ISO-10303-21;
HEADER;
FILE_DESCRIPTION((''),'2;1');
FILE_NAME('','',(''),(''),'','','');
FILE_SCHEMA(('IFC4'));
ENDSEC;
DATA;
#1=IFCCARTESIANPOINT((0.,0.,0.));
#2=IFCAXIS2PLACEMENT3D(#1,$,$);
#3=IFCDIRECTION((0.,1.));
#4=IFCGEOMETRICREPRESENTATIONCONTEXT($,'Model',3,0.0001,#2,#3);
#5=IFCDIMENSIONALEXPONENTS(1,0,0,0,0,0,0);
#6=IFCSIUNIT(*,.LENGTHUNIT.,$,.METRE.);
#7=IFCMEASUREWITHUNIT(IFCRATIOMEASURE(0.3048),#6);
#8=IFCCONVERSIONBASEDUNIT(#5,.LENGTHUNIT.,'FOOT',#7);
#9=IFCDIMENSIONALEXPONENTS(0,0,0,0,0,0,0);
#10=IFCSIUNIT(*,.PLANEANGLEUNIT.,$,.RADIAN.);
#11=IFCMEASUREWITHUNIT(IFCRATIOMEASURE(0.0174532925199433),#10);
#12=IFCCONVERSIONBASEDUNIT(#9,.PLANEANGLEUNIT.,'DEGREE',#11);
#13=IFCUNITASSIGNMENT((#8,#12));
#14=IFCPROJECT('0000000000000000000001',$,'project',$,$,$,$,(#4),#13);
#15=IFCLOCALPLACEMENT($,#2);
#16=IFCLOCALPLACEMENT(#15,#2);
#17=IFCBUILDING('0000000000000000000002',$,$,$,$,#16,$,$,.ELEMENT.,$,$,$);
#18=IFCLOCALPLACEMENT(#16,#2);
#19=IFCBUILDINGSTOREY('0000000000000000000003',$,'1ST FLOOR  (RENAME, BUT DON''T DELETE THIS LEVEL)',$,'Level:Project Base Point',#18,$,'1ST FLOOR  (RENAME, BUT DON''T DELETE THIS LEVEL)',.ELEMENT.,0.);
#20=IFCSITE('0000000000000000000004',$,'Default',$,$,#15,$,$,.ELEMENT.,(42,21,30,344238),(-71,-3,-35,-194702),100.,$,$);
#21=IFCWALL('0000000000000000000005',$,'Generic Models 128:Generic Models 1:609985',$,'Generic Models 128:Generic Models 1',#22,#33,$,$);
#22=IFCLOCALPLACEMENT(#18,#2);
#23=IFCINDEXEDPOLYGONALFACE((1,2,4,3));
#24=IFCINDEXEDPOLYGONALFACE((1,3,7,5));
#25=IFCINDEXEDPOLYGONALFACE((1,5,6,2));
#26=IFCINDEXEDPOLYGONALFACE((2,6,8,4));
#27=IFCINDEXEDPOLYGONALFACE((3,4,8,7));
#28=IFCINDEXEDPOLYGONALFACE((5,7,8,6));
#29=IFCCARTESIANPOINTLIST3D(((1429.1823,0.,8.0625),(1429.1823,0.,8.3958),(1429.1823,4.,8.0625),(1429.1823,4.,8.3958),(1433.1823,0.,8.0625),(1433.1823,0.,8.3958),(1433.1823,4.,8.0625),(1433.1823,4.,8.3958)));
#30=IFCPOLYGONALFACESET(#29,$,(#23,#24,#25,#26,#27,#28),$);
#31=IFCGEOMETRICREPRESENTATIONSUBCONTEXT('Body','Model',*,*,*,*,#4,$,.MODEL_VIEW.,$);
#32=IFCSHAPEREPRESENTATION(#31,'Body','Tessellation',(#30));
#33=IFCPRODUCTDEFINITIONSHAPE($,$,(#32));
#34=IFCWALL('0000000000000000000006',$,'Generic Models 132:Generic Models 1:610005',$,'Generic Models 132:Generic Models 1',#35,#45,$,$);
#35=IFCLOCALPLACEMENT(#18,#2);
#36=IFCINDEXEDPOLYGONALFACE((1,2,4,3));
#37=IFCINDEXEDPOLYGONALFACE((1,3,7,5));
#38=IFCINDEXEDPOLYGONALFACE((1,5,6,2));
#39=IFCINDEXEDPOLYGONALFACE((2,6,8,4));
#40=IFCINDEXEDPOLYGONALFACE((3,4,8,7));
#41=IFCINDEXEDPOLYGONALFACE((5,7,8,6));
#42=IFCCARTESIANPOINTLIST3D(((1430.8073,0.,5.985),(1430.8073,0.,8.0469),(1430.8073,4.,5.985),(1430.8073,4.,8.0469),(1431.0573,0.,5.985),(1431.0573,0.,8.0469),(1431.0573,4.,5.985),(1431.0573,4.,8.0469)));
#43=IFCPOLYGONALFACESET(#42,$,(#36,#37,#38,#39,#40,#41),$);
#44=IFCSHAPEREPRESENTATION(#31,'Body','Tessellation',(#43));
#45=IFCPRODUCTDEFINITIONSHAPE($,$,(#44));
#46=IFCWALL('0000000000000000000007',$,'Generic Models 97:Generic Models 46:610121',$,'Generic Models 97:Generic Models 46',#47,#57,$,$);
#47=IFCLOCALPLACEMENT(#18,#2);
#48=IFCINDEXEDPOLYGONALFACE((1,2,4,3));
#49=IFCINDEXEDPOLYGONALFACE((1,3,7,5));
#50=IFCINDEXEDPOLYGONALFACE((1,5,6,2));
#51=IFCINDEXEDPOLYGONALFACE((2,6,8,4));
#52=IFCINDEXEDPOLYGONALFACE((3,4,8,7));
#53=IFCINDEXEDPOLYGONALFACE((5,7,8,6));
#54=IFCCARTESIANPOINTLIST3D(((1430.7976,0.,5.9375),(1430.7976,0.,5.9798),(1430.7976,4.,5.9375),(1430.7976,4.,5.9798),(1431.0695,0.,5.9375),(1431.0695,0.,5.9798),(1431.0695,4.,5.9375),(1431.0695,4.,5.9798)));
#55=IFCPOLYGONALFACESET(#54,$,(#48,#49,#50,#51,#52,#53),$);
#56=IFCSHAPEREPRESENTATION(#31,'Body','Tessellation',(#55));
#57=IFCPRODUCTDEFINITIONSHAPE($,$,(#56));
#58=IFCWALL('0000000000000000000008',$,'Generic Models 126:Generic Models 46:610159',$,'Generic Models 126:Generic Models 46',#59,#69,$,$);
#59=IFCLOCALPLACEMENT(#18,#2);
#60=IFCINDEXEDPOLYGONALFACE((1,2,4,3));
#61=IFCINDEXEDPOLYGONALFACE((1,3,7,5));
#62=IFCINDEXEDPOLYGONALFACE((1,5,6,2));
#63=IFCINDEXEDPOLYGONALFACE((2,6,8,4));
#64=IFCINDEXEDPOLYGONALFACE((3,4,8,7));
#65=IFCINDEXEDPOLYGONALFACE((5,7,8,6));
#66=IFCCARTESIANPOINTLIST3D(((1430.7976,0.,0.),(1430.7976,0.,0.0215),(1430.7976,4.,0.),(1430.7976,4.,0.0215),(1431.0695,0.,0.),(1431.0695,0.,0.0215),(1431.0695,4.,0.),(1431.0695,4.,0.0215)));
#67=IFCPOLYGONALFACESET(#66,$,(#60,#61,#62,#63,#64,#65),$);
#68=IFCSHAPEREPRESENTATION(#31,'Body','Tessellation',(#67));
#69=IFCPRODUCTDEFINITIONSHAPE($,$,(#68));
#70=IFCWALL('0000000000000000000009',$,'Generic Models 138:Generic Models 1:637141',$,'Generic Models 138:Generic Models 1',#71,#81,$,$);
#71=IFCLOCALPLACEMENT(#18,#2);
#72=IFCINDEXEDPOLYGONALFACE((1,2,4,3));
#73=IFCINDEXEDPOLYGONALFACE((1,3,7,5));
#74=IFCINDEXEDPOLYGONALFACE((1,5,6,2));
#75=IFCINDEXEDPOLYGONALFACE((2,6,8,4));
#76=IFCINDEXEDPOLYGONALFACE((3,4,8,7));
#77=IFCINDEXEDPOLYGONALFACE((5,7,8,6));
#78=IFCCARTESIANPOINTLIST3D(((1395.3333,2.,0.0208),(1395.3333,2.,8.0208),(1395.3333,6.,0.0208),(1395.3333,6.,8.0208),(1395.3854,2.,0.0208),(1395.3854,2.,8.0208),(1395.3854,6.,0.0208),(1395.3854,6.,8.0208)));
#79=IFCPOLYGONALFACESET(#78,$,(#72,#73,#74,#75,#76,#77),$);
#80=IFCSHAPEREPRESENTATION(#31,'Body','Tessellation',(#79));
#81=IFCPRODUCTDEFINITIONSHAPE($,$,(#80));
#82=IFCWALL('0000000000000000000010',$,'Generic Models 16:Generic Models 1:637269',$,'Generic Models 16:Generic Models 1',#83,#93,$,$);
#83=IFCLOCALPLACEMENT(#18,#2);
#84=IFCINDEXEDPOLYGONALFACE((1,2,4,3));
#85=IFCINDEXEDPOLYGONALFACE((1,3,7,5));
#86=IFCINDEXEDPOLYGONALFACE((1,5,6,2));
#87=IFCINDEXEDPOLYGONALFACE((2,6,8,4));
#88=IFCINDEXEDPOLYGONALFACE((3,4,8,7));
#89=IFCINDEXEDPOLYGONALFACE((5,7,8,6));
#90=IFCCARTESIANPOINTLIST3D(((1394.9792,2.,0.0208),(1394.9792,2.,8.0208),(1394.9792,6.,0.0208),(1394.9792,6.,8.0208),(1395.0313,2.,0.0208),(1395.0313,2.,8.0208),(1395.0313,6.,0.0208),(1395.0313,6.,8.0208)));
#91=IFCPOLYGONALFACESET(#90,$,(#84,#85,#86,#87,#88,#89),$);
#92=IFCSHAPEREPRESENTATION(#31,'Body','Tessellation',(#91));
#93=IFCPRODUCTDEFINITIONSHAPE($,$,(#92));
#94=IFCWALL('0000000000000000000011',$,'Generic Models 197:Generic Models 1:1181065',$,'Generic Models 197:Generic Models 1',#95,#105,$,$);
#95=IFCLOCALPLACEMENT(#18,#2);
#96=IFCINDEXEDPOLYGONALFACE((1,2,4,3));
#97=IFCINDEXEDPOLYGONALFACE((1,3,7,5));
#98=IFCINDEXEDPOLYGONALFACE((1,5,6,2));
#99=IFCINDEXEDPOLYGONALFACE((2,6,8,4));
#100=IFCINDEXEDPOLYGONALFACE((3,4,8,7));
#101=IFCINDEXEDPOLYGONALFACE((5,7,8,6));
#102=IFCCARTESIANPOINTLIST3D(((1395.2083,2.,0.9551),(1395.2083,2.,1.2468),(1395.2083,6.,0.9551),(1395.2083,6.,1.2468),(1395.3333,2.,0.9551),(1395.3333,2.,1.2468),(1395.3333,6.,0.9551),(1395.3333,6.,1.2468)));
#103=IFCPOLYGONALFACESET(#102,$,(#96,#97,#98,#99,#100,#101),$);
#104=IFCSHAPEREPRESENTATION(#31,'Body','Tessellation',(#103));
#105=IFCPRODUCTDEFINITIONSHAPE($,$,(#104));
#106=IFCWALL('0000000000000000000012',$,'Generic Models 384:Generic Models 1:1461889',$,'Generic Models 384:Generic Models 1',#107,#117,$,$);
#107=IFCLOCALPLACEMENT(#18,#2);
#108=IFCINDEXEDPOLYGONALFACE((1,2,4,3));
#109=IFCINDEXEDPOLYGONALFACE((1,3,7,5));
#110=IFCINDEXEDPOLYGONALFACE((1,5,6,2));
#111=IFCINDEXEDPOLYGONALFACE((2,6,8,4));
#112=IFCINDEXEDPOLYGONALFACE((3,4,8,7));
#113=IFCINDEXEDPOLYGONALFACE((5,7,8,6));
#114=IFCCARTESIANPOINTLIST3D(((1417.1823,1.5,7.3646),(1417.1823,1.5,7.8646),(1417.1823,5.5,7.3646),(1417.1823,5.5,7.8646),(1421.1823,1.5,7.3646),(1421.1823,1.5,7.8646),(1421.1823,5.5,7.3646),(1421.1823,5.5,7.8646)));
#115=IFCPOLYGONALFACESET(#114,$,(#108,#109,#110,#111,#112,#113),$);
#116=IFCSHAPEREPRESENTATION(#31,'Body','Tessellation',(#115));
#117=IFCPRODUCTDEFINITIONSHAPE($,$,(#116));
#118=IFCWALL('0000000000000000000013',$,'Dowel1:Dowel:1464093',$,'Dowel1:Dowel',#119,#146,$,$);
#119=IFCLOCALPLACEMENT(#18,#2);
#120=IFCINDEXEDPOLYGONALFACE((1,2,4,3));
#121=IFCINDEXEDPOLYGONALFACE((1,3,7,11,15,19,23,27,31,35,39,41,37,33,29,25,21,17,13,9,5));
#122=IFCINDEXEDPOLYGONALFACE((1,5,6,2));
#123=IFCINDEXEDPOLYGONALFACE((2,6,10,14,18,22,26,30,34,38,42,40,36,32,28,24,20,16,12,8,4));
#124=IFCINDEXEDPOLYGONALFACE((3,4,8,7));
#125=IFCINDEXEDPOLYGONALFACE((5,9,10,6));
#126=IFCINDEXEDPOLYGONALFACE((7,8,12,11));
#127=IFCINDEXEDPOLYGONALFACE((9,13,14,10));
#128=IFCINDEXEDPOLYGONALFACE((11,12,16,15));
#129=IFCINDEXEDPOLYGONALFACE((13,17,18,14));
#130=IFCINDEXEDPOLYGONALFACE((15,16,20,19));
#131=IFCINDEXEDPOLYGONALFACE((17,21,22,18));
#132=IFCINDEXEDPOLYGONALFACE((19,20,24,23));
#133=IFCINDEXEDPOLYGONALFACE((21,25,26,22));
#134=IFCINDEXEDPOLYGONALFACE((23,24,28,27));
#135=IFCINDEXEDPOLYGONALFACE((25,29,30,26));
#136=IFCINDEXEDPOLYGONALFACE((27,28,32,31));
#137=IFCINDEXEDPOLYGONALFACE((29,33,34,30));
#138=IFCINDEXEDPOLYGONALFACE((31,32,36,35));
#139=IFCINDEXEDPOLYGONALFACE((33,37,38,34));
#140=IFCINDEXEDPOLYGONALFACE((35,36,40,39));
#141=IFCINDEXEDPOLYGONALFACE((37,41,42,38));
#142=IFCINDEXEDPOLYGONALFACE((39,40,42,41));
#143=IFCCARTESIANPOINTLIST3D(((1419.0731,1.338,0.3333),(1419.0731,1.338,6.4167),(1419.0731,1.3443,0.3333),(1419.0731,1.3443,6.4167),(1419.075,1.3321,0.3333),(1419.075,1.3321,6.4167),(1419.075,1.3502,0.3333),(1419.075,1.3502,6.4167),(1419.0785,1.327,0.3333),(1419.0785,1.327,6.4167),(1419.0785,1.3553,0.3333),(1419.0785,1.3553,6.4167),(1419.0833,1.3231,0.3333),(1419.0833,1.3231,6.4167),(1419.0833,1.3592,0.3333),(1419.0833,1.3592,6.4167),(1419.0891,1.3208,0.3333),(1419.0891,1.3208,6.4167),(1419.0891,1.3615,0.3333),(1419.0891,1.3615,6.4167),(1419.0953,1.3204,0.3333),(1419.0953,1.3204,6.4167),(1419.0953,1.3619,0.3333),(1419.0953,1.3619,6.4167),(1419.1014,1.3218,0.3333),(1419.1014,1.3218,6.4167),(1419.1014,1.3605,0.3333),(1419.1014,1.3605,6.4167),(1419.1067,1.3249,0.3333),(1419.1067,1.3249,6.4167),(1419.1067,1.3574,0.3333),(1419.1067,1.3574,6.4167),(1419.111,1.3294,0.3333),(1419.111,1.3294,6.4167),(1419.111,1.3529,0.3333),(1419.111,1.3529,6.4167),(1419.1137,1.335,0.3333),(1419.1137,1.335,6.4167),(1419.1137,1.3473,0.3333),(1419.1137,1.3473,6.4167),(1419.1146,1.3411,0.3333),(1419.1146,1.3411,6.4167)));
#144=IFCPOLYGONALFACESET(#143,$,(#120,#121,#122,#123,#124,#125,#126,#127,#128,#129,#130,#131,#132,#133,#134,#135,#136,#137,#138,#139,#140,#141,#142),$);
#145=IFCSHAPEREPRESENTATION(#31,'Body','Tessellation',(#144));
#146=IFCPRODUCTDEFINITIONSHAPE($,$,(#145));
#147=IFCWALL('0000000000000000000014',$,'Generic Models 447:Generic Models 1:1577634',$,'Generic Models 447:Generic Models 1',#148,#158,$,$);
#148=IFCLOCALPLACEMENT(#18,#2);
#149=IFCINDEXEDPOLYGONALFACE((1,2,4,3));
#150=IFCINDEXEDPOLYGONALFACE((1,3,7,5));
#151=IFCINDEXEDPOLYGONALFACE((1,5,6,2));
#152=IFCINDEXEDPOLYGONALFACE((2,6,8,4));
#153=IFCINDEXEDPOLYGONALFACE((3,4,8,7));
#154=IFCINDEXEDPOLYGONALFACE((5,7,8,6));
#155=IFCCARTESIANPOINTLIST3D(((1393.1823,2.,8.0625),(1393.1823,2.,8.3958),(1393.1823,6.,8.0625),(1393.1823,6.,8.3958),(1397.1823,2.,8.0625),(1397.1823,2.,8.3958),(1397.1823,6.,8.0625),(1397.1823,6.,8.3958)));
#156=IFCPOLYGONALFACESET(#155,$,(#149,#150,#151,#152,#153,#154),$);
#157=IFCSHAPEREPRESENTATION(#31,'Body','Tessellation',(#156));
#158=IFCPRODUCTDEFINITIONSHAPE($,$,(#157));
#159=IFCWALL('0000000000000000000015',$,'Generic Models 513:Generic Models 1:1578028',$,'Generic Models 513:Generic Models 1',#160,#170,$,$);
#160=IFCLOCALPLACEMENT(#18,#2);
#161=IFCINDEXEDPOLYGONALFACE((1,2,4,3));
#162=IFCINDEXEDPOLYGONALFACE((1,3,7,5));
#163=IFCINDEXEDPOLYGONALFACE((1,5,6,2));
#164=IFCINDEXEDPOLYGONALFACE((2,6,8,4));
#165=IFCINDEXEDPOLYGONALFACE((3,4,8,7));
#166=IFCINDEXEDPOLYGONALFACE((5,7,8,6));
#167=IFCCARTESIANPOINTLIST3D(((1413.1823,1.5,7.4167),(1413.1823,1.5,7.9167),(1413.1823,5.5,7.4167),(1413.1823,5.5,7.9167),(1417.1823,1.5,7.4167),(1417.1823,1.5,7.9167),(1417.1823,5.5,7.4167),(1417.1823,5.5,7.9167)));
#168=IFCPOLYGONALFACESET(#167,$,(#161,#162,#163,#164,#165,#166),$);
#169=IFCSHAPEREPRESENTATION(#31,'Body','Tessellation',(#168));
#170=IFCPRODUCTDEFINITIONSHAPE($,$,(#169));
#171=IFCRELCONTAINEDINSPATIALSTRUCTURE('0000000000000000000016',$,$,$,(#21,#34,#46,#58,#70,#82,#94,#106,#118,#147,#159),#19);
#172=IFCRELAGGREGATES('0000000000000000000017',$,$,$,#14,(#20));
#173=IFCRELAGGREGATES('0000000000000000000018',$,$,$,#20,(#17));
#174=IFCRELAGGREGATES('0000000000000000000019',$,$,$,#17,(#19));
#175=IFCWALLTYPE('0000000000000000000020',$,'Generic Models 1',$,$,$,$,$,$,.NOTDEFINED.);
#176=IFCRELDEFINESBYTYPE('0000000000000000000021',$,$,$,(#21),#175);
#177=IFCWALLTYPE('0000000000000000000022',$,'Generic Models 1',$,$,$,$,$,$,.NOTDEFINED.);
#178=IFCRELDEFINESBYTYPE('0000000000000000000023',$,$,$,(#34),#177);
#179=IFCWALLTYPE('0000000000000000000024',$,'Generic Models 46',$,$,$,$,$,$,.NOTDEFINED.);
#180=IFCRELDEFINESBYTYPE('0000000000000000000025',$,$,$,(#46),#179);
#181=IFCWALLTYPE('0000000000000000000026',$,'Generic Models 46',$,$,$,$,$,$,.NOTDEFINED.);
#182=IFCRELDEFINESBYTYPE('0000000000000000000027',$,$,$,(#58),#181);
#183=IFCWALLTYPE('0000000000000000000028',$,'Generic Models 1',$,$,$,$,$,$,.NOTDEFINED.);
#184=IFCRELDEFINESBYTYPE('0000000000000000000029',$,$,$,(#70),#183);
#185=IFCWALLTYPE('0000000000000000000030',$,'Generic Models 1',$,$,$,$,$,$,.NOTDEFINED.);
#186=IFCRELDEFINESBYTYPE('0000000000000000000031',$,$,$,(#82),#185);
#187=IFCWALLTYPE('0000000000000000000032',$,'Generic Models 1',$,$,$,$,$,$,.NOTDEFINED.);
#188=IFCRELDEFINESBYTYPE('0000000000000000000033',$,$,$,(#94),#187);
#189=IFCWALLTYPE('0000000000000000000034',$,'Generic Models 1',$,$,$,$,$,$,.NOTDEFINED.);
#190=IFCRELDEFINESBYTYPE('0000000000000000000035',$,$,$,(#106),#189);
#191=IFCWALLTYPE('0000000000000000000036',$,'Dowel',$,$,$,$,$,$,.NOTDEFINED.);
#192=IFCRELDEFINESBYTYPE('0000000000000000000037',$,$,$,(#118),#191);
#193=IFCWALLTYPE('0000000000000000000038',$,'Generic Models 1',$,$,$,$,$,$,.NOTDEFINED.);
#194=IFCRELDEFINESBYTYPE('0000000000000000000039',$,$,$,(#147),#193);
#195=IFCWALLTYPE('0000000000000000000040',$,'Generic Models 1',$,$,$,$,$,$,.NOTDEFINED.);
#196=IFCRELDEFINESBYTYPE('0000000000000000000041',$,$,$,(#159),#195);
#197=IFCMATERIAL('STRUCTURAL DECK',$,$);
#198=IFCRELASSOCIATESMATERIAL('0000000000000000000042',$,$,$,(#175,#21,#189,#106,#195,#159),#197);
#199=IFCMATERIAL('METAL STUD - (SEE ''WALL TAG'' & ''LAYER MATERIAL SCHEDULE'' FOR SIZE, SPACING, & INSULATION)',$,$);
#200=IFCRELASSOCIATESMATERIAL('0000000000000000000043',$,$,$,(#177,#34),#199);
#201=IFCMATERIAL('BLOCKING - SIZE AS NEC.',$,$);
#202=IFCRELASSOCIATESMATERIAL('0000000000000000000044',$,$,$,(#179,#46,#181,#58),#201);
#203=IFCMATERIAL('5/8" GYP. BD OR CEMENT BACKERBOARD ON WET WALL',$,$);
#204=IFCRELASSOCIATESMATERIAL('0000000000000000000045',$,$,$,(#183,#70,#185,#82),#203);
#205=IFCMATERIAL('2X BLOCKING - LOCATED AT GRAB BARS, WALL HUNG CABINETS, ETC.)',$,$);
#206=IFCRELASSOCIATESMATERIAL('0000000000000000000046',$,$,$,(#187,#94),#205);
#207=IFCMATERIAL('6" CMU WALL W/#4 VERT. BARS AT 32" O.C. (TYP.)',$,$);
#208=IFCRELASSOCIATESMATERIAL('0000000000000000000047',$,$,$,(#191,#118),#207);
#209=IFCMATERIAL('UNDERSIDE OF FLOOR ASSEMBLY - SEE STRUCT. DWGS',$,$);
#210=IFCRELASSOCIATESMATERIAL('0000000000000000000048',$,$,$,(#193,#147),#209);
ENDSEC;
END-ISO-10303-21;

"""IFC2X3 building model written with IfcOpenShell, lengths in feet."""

from ifc_helpers import new_model, entity, si_unit, converted_unit, direction, frame, frame_2d, origin, origin_2d_with_axis, place, context, subcontext, project, spatial, rectangle, circle, extrude, material, type_object, element, save


model = new_model("IFC2X3")

# Units and contexts
model_context = context("Model", 3, precision=0.0001, world=origin(), true_north=direction((0.0, 1.0)))
body_context = subcontext(model_context, "Body", "Model", "MODEL_VIEW")
ifc_project = project(units=[converted_unit("LENGTHUNIT", "FOOT", entity("IfcRatioMeasure", 0.3048), si_unit("LENGTHUNIT", "METRE"), dimensions=[1, 0, 0, 0, 0, 0, 0]), converted_unit("PLANEANGLEUNIT", "DEGREE", entity("IfcRatioMeasure", 0.0174532925199433), si_unit("PLANEANGLEUNIT", "RADIAN"), dimensions=[0, 0, 0, 0, 0, 0, 0])], contexts=[model_context])

# Site, building, storey
site_placement = place(None, origin())
site = spatial("IfcSite", under=ifc_project, at=site_placement, Name="Default", CompositionType="ELEMENT", RefLatitude=(42, 21, 30, 344238), RefLongitude=(-71, -3, -35, -194702), RefElevation=100.0)
building_placement = place(site_placement, origin())
building = spatial("IfcBuilding", under=site, at=building_placement, CompositionType="ELEMENT")
storey_placement = place(building_placement, origin())
storey = spatial("IfcBuildingStorey", under=building, at=storey_placement, Name="1ST FLOOR  (RENAME, BUT DON'T DELETE THIS LEVEL)", ObjectType="Level:Project Base Point", LongName="1ST FLOOR  (RENAME, BUT DON'T DELETE THIS LEVEL)", CompositionType="ELEMENT", Elevation=0.0)

# Walls
ifc_material_1 = material(Name="STRUCTURAL DECK")
wall_type_1 = type_object("IfcWallType", Name="Generic Models 1", PredefinedType="NOTDEFINED", material=ifc_material_1)
wall_1_placement = place(storey_placement, frame((1429.1823, 0.0, 8.0625), z_axis=(0.0, 0.0, 1.0), x_axis=(0.0, 1.0, 0.0)))
element("IfcWall", 1, at=wall_1_placement, inside=storey, type_object=wall_type_1, material=ifc_material_1, Name="Generic Models 128:Generic Models 1:609985", ObjectType="Generic Models 128:Generic Models 1", context=body_context, shape_type="SweptSolid", body=[
    extrude(rectangle(XDim=4.0, YDim=4.0, at=origin_2d_with_axis()), frame((2.0, -2.0, 0.0)), (0.0, 0.0, 1.0), 0.3333),
])
ifc_material_2 = material(Name="METAL STUD - (SEE 'WALL TAG' & 'LAYER MATERIAL SCHEDULE' FOR SIZE, SPACING, & INSULATION)")
wall_type_2 = type_object("IfcWallType", Name="Generic Models 1", PredefinedType="NOTDEFINED", material=ifc_material_2)
wall_2_placement = place(storey_placement, frame((1430.8073, 0.0, 5.985), z_axis=(0.0, 0.0, 1.0), x_axis=(0.0, 1.0, 0.0)))
element("IfcWall", 2, at=wall_2_placement, inside=storey, type_object=wall_type_2, material=ifc_material_2, Name="Generic Models 132:Generic Models 1:610005", ObjectType="Generic Models 132:Generic Models 1", context=body_context, shape_type="SweptSolid", body=[
    extrude(rectangle(XDim=0.25, YDim=4.0, at=frame_2d((0.0, 0.0), x_axis=(1.0, 0.0))), frame((2.0, -0.125, 0.0), z_axis=(0.0, 0.0, 1.0), x_axis=(0.0, 1.0, 0.0)), (0.0, 0.0, 1.0), 2.0618),
])
ifc_material_3 = material(Name="BLOCKING - SIZE AS NEC.")
wall_type_3 = type_object("IfcWallType", Name="Generic Models 46", PredefinedType="NOTDEFINED", material=ifc_material_3)
wall_3_placement = place(storey_placement, frame((1430.7976, 0.0, 5.9375), z_axis=(0.0, 0.0, 1.0), x_axis=(0.0, 1.0, 0.0)))
element("IfcWall", 3, at=wall_3_placement, inside=storey, type_object=wall_type_3, material=ifc_material_3, Name="Generic Models 97:Generic Models 46:610121", ObjectType="Generic Models 97:Generic Models 46", context=body_context, shape_type="SweptSolid", body=[
    extrude(rectangle(XDim=4.0, YDim=0.2719, at=frame_2d((0.0, 0.0), x_axis=(1.0, 0.0))), frame((2.0, -0.136, 0.0)), (0.0, 0.0, 1.0), 0.0423),
])
wall_type_4 = type_object("IfcWallType", Name="Generic Models 46", PredefinedType="NOTDEFINED", material=ifc_material_3)
wall_4_placement = place(storey_placement, frame((1430.7976, 0.0, 0.0), z_axis=(0.0, 0.0, 1.0), x_axis=(0.0, 1.0, 0.0)))
element("IfcWall", 4, at=wall_4_placement, inside=storey, type_object=wall_type_4, material=ifc_material_3, Name="Generic Models 126:Generic Models 46:610159", ObjectType="Generic Models 126:Generic Models 46", context=body_context, shape_type="SweptSolid", body=[
    extrude(rectangle(XDim=4.0, YDim=0.2719, at=frame_2d((0.0, 0.0), x_axis=(1.0, 0.0))), frame((2.0, -0.136, 0.0)), (0.0, 0.0, 1.0), 0.0215),
])
ifc_material_4 = material(Name="5/8\" GYP. BD OR CEMENT BACKERBOARD ON WET WALL")
wall_type_5 = type_object("IfcWallType", Name="Generic Models 1", PredefinedType="NOTDEFINED", material=ifc_material_4)
wall_5_placement = place(storey_placement, frame((1395.3333, 2.0, 0.0208), z_axis=(0.0, 0.0, 1.0), x_axis=(0.0, 1.0, 0.0)))
element("IfcWall", 5, at=wall_5_placement, inside=storey, type_object=wall_type_5, material=ifc_material_4, Name="Generic Models 138:Generic Models 1:637141", ObjectType="Generic Models 138:Generic Models 1", context=body_context, shape_type="SweptSolid", body=[
    extrude(rectangle(XDim=4.0, YDim=0.0521, at=frame_2d((0.0, 0.0), x_axis=(1.0, 0.0))), frame((2.0, -0.026, 0.0)), (0.0, 0.0, 1.0), 8.0),
])
wall_type_6 = type_object("IfcWallType", Name="Generic Models 1", PredefinedType="NOTDEFINED", material=ifc_material_4)
wall_6_placement = place(storey_placement, frame((1394.9792, 2.0, 0.0208), z_axis=(0.0, 0.0, 1.0), x_axis=(0.0, 1.0, 0.0)))
element("IfcWall", 6, at=wall_6_placement, inside=storey, type_object=wall_type_6, material=ifc_material_4, Name="Generic Models 16:Generic Models 1:637269", ObjectType="Generic Models 16:Generic Models 1", context=body_context, shape_type="SweptSolid", body=[
    extrude(rectangle(XDim=4.0, YDim=0.0521, at=frame_2d((0.0, 0.0), x_axis=(1.0, 0.0))), frame((2.0, -0.026, 0.0)), (0.0, 0.0, 1.0), 8.0),
])
ifc_material_5 = material(Name="2X BLOCKING - LOCATED AT GRAB BARS, WALL HUNG CABINETS, ETC.)")
wall_type_7 = type_object("IfcWallType", Name="Generic Models 1", PredefinedType="NOTDEFINED", material=ifc_material_5)
wall_7_placement = place(storey_placement, frame((1395.2083, 2.0, 0.9551), z_axis=(0.0, 0.0, 1.0), x_axis=(0.0, 1.0, 0.0)))
element("IfcWall", 7, at=wall_7_placement, inside=storey, type_object=wall_type_7, material=ifc_material_5, Name="Generic Models 197:Generic Models 1:1181065", ObjectType="Generic Models 197:Generic Models 1", context=body_context, shape_type="SweptSolid", body=[
    extrude(rectangle(XDim=4.0, YDim=0.125, at=frame_2d((0.0, 0.0), x_axis=(1.0, 0.0))), frame((2.0, -0.0625, 0.0)), (0.0, 0.0, 1.0), 0.2917),
])
wall_type_8 = type_object("IfcWallType", Name="Generic Models 1", PredefinedType="NOTDEFINED", material=ifc_material_1)
wall_8_placement = place(storey_placement, frame((1417.1823, 1.5, 7.3646), z_axis=(0.0, 0.0, 1.0), x_axis=(0.0, 1.0, 0.0)))
element("IfcWall", 8, at=wall_8_placement, inside=storey, type_object=wall_type_8, material=ifc_material_1, Name="Generic Models 384:Generic Models 1:1461889", ObjectType="Generic Models 384:Generic Models 1", context=body_context, shape_type="SweptSolid", body=[
    extrude(rectangle(XDim=4.0, YDim=4.0, at=frame_2d((0.0, 0.0), x_axis=(1.0, 0.0))), frame((2.0, -2.0, 0.0)), (0.0, 0.0, 1.0), 0.5),
])
ifc_material_6 = material(Name="6\" CMU WALL W/#4 VERT. BARS AT 32\" O.C. (TYP.)")
wall_type_9 = type_object("IfcWallType", Name="Dowel", PredefinedType="NOTDEFINED", material=ifc_material_6)
wall_9_placement = place(storey_placement, frame((1419.0729, 1.3203, 0.3333), z_axis=(0.0, 0.0, 1.0), x_axis=(0.0, 1.0, 0.0)))
element("IfcWall", 9, at=wall_9_placement, inside=storey, type_object=wall_type_9, material=ifc_material_6, Name="Dowel1:Dowel:1464093", ObjectType="Dowel1:Dowel", context=body_context, shape_type="SweptSolid", body=[
    extrude(circle(Radius=0.0208, at=frame_2d((0.0, 0.0), x_axis=(1.0, 0.0))), frame((0.0208, -0.0208, 0.0), z_axis=(0.0, 0.0, 1.0), x_axis=(0.0, -1.0, 0.0)), (0.0, 0.0, 1.0), 6.0833),
])
ifc_material_7 = material(Name="UNDERSIDE OF FLOOR ASSEMBLY - SEE STRUCT. DWGS")
wall_type_10 = type_object("IfcWallType", Name="Generic Models 1", PredefinedType="NOTDEFINED", material=ifc_material_7)
wall_10_placement = place(storey_placement, frame((1393.1823, 2.0, 8.0625), z_axis=(0.0, 0.0, 1.0), x_axis=(0.0, 1.0, 0.0)))
element("IfcWall", 10, at=wall_10_placement, inside=storey, type_object=wall_type_10, material=ifc_material_7, Name="Generic Models 447:Generic Models 1:1577634", ObjectType="Generic Models 447:Generic Models 1", context=body_context, shape_type="SweptSolid", body=[
    extrude(rectangle(XDim=4.0, YDim=4.0, at=origin_2d_with_axis()), frame((2.0, -2.0, 0.0)), (0.0, 0.0, 1.0), 0.3333),
])
wall_type_11 = type_object("IfcWallType", Name="Generic Models 1", PredefinedType="NOTDEFINED", material=ifc_material_1)
wall_11_placement = place(storey_placement, frame((1413.1823, 1.5, 7.4167), z_axis=(0.0, 0.0, 1.0), x_axis=(0.0, 1.0, 0.0)))
element("IfcWall", 11, at=wall_11_placement, inside=storey, type_object=wall_type_11, material=ifc_material_1, Name="Generic Models 513:Generic Models 1:1578028", ObjectType="Generic Models 513:Generic Models 1", context=body_context, shape_type="SweptSolid", body=[
    extrude(rectangle(XDim=4.0, YDim=4.0, at=frame_2d((0.0, 0.0), x_axis=(1.0, 0.0))), frame((2.0, -2.0, 0.0)), (0.0, 0.0, 1.0), 0.5),
])

save(model, "model.ifc")
